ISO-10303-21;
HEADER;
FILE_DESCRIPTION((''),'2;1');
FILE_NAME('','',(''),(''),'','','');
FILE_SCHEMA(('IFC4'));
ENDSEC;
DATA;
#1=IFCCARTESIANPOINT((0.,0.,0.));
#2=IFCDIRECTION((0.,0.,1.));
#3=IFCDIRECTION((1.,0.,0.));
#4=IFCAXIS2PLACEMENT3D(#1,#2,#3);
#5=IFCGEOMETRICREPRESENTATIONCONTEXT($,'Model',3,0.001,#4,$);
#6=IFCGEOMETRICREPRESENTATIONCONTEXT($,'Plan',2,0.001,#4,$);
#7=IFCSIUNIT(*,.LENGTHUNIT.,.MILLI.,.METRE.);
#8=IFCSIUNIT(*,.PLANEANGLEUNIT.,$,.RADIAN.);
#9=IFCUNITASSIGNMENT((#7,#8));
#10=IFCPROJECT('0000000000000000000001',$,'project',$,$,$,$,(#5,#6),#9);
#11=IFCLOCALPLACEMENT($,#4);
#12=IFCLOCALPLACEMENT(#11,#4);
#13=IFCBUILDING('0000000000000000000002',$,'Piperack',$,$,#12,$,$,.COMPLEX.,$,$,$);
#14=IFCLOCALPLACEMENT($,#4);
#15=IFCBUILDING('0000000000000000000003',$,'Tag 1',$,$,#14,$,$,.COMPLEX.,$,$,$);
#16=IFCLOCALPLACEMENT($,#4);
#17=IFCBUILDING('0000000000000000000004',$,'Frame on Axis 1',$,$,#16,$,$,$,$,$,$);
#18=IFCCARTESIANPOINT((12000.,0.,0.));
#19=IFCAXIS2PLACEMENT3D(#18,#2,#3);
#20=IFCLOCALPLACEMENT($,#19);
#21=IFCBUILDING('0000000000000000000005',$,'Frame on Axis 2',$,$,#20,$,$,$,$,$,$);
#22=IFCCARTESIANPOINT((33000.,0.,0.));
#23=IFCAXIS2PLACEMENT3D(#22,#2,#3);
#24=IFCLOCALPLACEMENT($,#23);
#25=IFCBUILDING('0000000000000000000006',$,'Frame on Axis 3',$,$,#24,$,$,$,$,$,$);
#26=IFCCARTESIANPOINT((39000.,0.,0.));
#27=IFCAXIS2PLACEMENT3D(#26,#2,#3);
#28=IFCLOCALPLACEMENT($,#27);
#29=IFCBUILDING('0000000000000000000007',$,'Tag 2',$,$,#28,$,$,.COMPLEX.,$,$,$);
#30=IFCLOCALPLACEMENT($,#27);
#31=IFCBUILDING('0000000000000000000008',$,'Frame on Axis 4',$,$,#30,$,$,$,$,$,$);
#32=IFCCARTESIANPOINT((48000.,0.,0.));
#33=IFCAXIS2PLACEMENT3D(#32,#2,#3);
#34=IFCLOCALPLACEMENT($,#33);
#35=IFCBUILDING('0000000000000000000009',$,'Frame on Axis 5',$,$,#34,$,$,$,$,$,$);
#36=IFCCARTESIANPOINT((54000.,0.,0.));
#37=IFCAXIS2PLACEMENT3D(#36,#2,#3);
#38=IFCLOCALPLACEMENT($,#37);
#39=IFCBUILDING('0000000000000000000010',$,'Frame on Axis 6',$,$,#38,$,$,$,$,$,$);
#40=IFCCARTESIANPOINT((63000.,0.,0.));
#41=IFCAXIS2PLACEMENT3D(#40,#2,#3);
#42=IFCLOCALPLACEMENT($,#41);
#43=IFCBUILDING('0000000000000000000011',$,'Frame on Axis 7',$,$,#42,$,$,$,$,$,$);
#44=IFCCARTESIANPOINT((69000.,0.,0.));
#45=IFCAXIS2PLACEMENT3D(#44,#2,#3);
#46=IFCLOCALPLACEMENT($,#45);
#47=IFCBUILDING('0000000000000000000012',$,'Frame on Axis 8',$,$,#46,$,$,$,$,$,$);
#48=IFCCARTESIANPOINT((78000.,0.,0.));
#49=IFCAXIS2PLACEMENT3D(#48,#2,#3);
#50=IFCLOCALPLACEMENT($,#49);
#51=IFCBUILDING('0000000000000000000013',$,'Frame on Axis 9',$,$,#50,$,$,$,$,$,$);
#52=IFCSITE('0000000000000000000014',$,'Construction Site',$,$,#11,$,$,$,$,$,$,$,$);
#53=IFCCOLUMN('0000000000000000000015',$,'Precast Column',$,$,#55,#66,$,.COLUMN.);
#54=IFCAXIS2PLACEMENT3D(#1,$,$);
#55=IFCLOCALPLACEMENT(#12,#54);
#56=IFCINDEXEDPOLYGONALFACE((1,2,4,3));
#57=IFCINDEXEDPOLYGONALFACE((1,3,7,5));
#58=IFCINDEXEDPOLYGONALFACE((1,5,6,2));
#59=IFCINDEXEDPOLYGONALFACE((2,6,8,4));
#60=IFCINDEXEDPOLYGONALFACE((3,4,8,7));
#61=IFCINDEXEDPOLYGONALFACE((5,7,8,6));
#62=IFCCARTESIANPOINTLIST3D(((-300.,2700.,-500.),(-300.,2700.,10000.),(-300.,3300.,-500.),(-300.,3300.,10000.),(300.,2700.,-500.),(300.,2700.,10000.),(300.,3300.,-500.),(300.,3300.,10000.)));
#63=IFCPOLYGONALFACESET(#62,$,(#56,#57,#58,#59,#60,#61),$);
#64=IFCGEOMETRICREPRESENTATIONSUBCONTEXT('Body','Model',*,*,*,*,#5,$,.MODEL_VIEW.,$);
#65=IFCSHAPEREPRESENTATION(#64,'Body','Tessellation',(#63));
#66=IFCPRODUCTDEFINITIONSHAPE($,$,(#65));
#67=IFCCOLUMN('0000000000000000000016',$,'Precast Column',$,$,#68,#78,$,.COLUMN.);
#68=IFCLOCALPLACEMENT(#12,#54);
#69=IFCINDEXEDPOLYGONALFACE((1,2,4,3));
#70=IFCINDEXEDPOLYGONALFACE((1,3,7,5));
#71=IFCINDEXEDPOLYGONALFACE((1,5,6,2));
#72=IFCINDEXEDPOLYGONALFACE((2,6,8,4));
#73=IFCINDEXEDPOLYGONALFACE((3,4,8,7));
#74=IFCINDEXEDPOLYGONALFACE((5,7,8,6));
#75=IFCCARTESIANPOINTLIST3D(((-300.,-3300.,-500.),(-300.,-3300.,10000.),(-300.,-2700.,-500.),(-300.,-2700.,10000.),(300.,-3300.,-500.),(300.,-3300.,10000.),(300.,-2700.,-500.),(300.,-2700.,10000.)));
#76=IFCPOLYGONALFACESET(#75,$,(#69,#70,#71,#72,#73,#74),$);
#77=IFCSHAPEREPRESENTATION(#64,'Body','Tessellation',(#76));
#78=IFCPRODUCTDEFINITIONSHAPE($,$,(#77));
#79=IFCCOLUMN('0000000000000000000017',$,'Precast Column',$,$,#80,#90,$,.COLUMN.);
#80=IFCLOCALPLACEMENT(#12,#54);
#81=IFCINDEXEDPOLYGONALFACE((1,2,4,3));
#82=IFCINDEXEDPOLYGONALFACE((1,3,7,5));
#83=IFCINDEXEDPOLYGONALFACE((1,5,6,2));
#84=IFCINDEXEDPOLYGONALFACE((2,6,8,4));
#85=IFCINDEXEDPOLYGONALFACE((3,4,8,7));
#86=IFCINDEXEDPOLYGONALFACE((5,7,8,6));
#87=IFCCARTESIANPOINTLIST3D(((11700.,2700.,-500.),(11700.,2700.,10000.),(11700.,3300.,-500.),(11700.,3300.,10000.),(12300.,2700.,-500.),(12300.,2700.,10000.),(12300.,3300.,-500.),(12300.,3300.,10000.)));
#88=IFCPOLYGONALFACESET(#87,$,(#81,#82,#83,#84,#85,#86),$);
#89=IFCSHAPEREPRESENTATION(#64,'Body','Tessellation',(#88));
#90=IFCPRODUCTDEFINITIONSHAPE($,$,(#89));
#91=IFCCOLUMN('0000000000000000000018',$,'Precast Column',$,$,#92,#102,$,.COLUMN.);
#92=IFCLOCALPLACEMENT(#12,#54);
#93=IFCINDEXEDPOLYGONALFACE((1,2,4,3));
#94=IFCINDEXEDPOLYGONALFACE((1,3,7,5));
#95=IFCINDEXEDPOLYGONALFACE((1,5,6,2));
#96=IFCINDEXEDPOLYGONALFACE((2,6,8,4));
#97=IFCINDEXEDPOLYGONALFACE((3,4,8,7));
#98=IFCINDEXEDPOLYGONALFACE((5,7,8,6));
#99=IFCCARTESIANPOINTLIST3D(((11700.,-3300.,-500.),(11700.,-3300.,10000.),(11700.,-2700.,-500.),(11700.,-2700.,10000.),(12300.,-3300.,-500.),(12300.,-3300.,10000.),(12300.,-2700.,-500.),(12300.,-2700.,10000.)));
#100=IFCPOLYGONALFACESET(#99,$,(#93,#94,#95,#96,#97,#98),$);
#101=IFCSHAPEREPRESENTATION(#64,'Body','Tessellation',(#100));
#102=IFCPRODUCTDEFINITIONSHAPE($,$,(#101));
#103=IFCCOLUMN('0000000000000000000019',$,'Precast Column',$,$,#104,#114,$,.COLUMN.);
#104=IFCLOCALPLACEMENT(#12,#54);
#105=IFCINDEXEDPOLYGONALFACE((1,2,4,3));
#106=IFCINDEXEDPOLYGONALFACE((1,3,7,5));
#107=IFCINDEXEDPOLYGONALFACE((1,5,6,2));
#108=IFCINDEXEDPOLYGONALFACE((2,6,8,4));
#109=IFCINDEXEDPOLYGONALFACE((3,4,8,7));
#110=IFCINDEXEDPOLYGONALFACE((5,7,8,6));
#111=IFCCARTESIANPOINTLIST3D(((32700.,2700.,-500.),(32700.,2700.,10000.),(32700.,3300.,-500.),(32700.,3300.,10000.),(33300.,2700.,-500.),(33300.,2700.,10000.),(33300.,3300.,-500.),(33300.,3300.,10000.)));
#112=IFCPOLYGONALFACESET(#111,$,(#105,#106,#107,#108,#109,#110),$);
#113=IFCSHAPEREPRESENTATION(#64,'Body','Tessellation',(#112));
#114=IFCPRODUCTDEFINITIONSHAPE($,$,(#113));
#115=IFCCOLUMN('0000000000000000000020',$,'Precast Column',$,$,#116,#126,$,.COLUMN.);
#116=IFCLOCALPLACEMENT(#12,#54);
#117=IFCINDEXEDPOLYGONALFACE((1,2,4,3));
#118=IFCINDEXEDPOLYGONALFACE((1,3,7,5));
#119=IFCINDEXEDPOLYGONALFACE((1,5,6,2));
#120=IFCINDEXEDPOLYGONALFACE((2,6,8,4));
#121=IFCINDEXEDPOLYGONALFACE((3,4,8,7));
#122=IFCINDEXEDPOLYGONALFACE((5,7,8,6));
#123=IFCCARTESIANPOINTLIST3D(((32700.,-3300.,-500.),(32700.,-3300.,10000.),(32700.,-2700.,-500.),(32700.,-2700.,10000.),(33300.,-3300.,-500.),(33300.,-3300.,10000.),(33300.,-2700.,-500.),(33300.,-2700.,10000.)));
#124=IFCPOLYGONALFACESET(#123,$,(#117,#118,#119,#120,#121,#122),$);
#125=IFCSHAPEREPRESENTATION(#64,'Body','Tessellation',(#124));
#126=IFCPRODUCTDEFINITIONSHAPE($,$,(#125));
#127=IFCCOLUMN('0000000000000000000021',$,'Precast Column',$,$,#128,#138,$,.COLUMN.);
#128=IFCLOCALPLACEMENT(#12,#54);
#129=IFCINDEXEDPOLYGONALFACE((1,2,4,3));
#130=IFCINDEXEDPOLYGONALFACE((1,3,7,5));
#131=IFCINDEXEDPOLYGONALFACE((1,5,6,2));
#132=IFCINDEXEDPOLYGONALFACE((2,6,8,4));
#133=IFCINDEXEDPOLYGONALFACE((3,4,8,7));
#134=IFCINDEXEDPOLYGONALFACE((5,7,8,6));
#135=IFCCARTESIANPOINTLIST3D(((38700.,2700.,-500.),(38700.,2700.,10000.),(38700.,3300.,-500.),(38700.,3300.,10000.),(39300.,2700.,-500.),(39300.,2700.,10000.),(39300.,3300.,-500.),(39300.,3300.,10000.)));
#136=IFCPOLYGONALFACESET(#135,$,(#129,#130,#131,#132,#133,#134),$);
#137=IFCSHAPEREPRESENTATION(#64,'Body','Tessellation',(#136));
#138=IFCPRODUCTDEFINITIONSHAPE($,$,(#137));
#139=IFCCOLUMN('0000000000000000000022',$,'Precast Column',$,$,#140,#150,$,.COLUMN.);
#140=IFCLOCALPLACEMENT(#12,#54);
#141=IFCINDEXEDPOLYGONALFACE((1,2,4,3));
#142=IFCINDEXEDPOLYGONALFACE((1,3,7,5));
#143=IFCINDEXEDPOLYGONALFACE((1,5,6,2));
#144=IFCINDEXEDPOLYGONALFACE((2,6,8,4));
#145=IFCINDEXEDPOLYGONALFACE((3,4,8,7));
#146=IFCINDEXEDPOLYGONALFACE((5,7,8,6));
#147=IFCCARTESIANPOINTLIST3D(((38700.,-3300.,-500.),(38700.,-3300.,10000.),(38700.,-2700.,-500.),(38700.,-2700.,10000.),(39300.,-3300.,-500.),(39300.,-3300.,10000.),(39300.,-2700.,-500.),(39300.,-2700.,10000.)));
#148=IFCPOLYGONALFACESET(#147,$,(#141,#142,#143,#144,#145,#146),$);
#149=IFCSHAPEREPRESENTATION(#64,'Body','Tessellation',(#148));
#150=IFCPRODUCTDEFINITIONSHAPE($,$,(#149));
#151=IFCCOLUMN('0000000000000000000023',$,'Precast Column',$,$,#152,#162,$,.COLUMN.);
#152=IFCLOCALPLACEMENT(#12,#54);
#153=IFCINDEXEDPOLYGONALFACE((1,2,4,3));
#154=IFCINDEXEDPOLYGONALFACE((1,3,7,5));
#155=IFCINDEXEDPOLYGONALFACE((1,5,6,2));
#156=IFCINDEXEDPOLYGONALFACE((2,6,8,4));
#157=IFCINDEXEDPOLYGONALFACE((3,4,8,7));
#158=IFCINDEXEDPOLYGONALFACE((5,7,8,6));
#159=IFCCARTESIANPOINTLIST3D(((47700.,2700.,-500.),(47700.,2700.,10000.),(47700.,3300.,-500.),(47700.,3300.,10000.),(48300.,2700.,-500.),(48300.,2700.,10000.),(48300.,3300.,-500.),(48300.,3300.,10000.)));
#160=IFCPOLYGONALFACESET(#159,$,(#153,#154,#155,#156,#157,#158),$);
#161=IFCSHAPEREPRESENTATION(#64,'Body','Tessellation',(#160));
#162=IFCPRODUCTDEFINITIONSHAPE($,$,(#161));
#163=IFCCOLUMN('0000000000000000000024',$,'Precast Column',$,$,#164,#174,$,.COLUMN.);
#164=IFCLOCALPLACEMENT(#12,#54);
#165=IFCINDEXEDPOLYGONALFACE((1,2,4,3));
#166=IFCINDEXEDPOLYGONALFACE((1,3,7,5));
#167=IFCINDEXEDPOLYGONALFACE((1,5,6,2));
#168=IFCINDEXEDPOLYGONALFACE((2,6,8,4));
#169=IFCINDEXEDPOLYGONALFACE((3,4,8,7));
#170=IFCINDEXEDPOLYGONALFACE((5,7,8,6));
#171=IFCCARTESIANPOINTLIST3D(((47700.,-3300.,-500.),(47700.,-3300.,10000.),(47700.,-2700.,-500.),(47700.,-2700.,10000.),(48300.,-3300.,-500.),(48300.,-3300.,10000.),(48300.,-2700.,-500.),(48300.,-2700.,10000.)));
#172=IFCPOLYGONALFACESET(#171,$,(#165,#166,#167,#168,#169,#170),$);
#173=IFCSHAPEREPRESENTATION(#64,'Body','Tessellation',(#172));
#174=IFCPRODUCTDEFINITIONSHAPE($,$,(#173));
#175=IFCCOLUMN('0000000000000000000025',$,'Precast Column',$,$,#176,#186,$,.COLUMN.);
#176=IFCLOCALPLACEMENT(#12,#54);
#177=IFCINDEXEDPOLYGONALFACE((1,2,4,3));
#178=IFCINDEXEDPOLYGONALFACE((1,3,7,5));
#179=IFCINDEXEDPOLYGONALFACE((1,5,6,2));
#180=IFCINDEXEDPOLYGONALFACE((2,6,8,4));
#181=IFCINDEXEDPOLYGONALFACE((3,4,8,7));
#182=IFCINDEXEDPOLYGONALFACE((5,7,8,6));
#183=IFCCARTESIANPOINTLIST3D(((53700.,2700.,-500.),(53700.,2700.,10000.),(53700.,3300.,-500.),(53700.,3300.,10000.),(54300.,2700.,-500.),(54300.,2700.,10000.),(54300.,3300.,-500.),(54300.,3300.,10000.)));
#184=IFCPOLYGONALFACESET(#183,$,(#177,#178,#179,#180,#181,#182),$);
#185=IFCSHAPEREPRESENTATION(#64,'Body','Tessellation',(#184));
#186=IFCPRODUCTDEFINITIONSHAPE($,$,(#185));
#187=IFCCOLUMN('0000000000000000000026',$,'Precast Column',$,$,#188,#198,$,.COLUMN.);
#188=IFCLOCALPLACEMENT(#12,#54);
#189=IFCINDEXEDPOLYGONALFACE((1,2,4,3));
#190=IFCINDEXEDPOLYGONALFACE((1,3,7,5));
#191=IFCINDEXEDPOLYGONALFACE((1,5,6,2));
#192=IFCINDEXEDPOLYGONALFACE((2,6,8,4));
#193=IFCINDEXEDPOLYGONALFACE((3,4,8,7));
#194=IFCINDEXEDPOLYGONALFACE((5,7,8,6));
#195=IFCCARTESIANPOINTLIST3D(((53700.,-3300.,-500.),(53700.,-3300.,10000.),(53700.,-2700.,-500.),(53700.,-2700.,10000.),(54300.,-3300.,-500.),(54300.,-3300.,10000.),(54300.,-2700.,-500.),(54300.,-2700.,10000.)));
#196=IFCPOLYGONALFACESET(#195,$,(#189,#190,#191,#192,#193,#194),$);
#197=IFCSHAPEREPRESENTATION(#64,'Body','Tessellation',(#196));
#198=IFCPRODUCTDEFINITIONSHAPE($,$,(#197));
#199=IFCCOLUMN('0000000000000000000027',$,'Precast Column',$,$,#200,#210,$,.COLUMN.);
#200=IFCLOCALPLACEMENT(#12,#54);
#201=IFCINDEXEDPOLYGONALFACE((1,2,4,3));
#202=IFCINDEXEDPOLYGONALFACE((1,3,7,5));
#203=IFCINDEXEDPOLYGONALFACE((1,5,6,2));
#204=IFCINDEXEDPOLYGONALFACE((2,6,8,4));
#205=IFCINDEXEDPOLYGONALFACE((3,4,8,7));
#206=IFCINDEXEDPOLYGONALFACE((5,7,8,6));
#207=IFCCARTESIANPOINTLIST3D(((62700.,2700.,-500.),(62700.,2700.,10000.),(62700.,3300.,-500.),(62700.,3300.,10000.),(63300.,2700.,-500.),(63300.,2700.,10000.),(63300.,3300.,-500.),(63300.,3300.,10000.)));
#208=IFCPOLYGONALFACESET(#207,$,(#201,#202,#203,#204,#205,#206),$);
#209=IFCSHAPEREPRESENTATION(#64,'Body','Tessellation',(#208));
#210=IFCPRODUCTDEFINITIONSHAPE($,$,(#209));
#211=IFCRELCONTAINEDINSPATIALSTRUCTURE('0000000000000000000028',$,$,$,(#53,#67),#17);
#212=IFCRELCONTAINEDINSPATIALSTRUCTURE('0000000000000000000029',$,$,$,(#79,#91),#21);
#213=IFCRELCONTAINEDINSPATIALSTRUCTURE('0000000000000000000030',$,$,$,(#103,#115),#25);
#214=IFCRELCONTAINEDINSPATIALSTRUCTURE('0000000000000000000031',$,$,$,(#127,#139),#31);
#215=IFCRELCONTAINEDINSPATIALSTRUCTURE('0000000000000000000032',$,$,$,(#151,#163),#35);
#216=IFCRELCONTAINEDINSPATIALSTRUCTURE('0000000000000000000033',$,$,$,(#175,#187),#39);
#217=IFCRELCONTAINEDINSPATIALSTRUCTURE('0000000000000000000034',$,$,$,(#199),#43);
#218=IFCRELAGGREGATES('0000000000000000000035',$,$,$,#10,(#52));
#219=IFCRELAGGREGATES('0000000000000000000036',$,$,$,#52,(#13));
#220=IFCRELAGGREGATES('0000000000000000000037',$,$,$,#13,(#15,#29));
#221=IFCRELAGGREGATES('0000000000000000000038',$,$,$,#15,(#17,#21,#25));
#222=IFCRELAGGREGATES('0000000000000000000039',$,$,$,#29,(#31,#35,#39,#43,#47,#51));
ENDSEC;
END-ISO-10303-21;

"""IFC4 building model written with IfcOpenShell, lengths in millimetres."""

from ifc_helpers import new_model, si_unit, frame, origin_with_axes, place, context, subcontext, project, spatial, rectangle, extrude, element, save


model = new_model("IFC4")

# Units and contexts
model_context = context("Model", 3, precision=0.001, world=origin_with_axes())
plan_context = context("Plan", 2, precision=0.001, world=origin_with_axes())
body_context = subcontext(model_context, "Body", "Model", "MODEL_VIEW")
ifc_project = project(units=[si_unit("LENGTHUNIT", "METRE", prefix="MILLI"), si_unit("PLANEANGLEUNIT", "RADIAN")], contexts=[model_context, plan_context])

# Site, buildings
site_placement = place(None, origin_with_axes())
site = spatial("IfcSite", under=ifc_project, at=site_placement, Name="Construction Site")
building_1_placement = place(site_placement, origin_with_axes())
building_1 = spatial("IfcBuilding", under=site, at=building_1_placement, Name="Piperack", CompositionType="COMPLEX")
building_2_placement = place(None, origin_with_axes())
building_2 = spatial("IfcBuilding", under=building_1, at=building_2_placement, Name="Tag 1", CompositionType="COMPLEX")
building_3_placement = place(None, origin_with_axes())
building_3 = spatial("IfcBuilding", under=building_2, at=building_3_placement, Name="Frame on Axis 1")

# Columns
for number, where, z_axis, x_axis, name in (
    (1, (0.0, 3000.0, -500.0), (0.0, 0.0, 1.0), (1.0, 0.0, 0.0), "Precast Column"),
    (2, (0.0, -3000.0, -500.0), (0.0, 0.0, 1.0), (1.0, 0.0, 0.0), "Precast Column"),
):
    element("IfcColumn", number, at=place(building_3_placement, frame(where, z_axis=z_axis, x_axis=x_axis)), inside=building_3, Name=name, PredefinedType="COLUMN", context=body_context, shape_type="SweptSolid", body=[
        extrude(rectangle(XDim=600.0, YDim=600.0), None, (0.0, 0.0, 1.0), 10500.0),
    ])

# Shared definitions
building_4_placement = place(None, frame((12000.0, 0.0, 0.0), z_axis=(0.0, 0.0, 1.0), x_axis=(1.0, 0.0, 0.0)))
building_4 = spatial("IfcBuilding", under=building_2, at=building_4_placement, Name="Frame on Axis 2")

# Columns
for number, where, z_axis, x_axis, name in (
    (3, (0.0, 3000.0, -500.0), (0.0, 0.0, 1.0), (1.0, 0.0, 0.0), "Precast Column"),
    (4, (0.0, -3000.0, -500.0), (0.0, 0.0, 1.0), (1.0, 0.0, 0.0), "Precast Column"),
):
    element("IfcColumn", number, at=place(building_4_placement, frame(where, z_axis=z_axis, x_axis=x_axis)), inside=building_4, Name=name, PredefinedType="COLUMN", context=body_context, shape_type="SweptSolid", body=[
        extrude(rectangle(XDim=600.0, YDim=600.0), None, (0.0, 0.0, 1.0), 10500.0),
    ])

# Shared definitions
building_5_placement = place(None, frame((33000.0, 0.0, 0.0), z_axis=(0.0, 0.0, 1.0), x_axis=(1.0, 0.0, 0.0)))
building_5 = spatial("IfcBuilding", under=building_2, at=building_5_placement, Name="Frame on Axis 3")

# Columns
for number, where, z_axis, x_axis, name in (
    (5, (0.0, 3000.0, -500.0), (0.0, 0.0, 1.0), (1.0, 0.0, 0.0), "Precast Column"),
    (6, (0.0, -3000.0, -500.0), (0.0, 0.0, 1.0), (1.0, 0.0, 0.0), "Precast Column"),
):
    element("IfcColumn", number, at=place(building_5_placement, frame(where, z_axis=z_axis, x_axis=x_axis)), inside=building_5, Name=name, PredefinedType="COLUMN", context=body_context, shape_type="SweptSolid", body=[
        extrude(rectangle(XDim=600.0, YDim=600.0), None, (0.0, 0.0, 1.0), 10500.0),
    ])

# Shared definitions
building_6_placement = place(None, frame((39000.0, 0.0, 0.0), z_axis=(0.0, 0.0, 1.0), x_axis=(1.0, 0.0, 0.0)))
building_6 = spatial("IfcBuilding", under=building_1, at=building_6_placement, Name="Tag 2", CompositionType="COMPLEX")
building_7_placement = place(None, frame((39000.0, 0.0, 0.0), z_axis=(0.0, 0.0, 1.0), x_axis=(1.0, 0.0, 0.0)))
building_7 = spatial("IfcBuilding", under=building_6, at=building_7_placement, Name="Frame on Axis 4")

# Columns
for number, where, z_axis, x_axis, name in (
    (7, (0.0, 3000.0, -500.0), (0.0, 0.0, 1.0), (1.0, 0.0, 0.0), "Precast Column"),
    (8, (0.0, -3000.0, -500.0), (0.0, 0.0, 1.0), (1.0, 0.0, 0.0), "Precast Column"),
):
    element("IfcColumn", number, at=place(building_7_placement, frame(where, z_axis=z_axis, x_axis=x_axis)), inside=building_7, Name=name, PredefinedType="COLUMN", context=body_context, shape_type="SweptSolid", body=[
        extrude(rectangle(XDim=600.0, YDim=600.0), None, (0.0, 0.0, 1.0), 10500.0),
    ])

# Shared definitions
building_8_placement = place(None, frame((48000.0, 0.0, 0.0), z_axis=(0.0, 0.0, 1.0), x_axis=(1.0, 0.0, 0.0)))
building_8 = spatial("IfcBuilding", under=building_6, at=building_8_placement, Name="Frame on Axis 5")

# Columns
for number, where, z_axis, x_axis, name in (
    (9, (0.0, 3000.0, -500.0), (0.0, 0.0, 1.0), (1.0, 0.0, 0.0), "Precast Column"),
    (10, (0.0, -3000.0, -500.0), (0.0, 0.0, 1.0), (1.0, 0.0, 0.0), "Precast Column"),
):
    element("IfcColumn", number, at=place(building_8_placement, frame(where, z_axis=z_axis, x_axis=x_axis)), inside=building_8, Name=name, PredefinedType="COLUMN", context=body_context, shape_type="SweptSolid", body=[
        extrude(rectangle(XDim=600.0, YDim=600.0), None, (0.0, 0.0, 1.0), 10500.0),
    ])

# Shared definitions
building_9_placement = place(None, frame((54000.0, 0.0, 0.0), z_axis=(0.0, 0.0, 1.0), x_axis=(1.0, 0.0, 0.0)))
building_9 = spatial("IfcBuilding", under=building_6, at=building_9_placement, Name="Frame on Axis 6")

# Columns
for number, where, z_axis, x_axis, name in (
    (11, (0.0, 3000.0, -500.0), (0.0, 0.0, 1.0), (1.0, 0.0, 0.0), "Precast Column"),
    (12, (0.0, -3000.0, -500.0), (0.0, 0.0, 1.0), (1.0, 0.0, 0.0), "Precast Column"),
):
    element("IfcColumn", number, at=place(building_9_placement, frame(where, z_axis=z_axis, x_axis=x_axis)), inside=building_9, Name=name, PredefinedType="COLUMN", context=body_context, shape_type="SweptSolid", body=[
        extrude(rectangle(XDim=600.0, YDim=600.0), None, (0.0, 0.0, 1.0), 10500.0),
    ])

# Shared definitions
building_10_placement = place(None, frame((63000.0, 0.0, 0.0), z_axis=(0.0, 0.0, 1.0), x_axis=(1.0, 0.0, 0.0)))
building_10 = spatial("IfcBuilding", under=building_6, at=building_10_placement, Name="Frame on Axis 7")

# Column
for number, where, z_axis, x_axis, name in (
    (13, (0.0, 3000.0, -500.0), (0.0, 0.0, 1.0), (1.0, 0.0, 0.0), "Precast Column"),
):
    element("IfcColumn", number, at=place(building_10_placement, frame(where, z_axis=z_axis, x_axis=x_axis)), inside=building_10, Name=name, PredefinedType="COLUMN", context=body_context, shape_type="SweptSolid", body=[
        extrude(rectangle(XDim=600.0, YDim=600.0), None, (0.0, 0.0, 1.0), 10500.0),
    ])

# Shared definitions
building_11_placement = place(None, frame((69000.0, 0.0, 0.0), z_axis=(0.0, 0.0, 1.0), x_axis=(1.0, 0.0, 0.0)))
building_11 = spatial("IfcBuilding", under=building_6, at=building_11_placement, Name="Frame on Axis 8")

# Shared definitions
building_12_placement = place(None, frame((78000.0, 0.0, 0.0), z_axis=(0.0, 0.0, 1.0), x_axis=(1.0, 0.0, 0.0)))
building_12 = spatial("IfcBuilding", under=building_6, at=building_12_placement, Name="Frame on Axis 9")

save(model, "model.ifc")
